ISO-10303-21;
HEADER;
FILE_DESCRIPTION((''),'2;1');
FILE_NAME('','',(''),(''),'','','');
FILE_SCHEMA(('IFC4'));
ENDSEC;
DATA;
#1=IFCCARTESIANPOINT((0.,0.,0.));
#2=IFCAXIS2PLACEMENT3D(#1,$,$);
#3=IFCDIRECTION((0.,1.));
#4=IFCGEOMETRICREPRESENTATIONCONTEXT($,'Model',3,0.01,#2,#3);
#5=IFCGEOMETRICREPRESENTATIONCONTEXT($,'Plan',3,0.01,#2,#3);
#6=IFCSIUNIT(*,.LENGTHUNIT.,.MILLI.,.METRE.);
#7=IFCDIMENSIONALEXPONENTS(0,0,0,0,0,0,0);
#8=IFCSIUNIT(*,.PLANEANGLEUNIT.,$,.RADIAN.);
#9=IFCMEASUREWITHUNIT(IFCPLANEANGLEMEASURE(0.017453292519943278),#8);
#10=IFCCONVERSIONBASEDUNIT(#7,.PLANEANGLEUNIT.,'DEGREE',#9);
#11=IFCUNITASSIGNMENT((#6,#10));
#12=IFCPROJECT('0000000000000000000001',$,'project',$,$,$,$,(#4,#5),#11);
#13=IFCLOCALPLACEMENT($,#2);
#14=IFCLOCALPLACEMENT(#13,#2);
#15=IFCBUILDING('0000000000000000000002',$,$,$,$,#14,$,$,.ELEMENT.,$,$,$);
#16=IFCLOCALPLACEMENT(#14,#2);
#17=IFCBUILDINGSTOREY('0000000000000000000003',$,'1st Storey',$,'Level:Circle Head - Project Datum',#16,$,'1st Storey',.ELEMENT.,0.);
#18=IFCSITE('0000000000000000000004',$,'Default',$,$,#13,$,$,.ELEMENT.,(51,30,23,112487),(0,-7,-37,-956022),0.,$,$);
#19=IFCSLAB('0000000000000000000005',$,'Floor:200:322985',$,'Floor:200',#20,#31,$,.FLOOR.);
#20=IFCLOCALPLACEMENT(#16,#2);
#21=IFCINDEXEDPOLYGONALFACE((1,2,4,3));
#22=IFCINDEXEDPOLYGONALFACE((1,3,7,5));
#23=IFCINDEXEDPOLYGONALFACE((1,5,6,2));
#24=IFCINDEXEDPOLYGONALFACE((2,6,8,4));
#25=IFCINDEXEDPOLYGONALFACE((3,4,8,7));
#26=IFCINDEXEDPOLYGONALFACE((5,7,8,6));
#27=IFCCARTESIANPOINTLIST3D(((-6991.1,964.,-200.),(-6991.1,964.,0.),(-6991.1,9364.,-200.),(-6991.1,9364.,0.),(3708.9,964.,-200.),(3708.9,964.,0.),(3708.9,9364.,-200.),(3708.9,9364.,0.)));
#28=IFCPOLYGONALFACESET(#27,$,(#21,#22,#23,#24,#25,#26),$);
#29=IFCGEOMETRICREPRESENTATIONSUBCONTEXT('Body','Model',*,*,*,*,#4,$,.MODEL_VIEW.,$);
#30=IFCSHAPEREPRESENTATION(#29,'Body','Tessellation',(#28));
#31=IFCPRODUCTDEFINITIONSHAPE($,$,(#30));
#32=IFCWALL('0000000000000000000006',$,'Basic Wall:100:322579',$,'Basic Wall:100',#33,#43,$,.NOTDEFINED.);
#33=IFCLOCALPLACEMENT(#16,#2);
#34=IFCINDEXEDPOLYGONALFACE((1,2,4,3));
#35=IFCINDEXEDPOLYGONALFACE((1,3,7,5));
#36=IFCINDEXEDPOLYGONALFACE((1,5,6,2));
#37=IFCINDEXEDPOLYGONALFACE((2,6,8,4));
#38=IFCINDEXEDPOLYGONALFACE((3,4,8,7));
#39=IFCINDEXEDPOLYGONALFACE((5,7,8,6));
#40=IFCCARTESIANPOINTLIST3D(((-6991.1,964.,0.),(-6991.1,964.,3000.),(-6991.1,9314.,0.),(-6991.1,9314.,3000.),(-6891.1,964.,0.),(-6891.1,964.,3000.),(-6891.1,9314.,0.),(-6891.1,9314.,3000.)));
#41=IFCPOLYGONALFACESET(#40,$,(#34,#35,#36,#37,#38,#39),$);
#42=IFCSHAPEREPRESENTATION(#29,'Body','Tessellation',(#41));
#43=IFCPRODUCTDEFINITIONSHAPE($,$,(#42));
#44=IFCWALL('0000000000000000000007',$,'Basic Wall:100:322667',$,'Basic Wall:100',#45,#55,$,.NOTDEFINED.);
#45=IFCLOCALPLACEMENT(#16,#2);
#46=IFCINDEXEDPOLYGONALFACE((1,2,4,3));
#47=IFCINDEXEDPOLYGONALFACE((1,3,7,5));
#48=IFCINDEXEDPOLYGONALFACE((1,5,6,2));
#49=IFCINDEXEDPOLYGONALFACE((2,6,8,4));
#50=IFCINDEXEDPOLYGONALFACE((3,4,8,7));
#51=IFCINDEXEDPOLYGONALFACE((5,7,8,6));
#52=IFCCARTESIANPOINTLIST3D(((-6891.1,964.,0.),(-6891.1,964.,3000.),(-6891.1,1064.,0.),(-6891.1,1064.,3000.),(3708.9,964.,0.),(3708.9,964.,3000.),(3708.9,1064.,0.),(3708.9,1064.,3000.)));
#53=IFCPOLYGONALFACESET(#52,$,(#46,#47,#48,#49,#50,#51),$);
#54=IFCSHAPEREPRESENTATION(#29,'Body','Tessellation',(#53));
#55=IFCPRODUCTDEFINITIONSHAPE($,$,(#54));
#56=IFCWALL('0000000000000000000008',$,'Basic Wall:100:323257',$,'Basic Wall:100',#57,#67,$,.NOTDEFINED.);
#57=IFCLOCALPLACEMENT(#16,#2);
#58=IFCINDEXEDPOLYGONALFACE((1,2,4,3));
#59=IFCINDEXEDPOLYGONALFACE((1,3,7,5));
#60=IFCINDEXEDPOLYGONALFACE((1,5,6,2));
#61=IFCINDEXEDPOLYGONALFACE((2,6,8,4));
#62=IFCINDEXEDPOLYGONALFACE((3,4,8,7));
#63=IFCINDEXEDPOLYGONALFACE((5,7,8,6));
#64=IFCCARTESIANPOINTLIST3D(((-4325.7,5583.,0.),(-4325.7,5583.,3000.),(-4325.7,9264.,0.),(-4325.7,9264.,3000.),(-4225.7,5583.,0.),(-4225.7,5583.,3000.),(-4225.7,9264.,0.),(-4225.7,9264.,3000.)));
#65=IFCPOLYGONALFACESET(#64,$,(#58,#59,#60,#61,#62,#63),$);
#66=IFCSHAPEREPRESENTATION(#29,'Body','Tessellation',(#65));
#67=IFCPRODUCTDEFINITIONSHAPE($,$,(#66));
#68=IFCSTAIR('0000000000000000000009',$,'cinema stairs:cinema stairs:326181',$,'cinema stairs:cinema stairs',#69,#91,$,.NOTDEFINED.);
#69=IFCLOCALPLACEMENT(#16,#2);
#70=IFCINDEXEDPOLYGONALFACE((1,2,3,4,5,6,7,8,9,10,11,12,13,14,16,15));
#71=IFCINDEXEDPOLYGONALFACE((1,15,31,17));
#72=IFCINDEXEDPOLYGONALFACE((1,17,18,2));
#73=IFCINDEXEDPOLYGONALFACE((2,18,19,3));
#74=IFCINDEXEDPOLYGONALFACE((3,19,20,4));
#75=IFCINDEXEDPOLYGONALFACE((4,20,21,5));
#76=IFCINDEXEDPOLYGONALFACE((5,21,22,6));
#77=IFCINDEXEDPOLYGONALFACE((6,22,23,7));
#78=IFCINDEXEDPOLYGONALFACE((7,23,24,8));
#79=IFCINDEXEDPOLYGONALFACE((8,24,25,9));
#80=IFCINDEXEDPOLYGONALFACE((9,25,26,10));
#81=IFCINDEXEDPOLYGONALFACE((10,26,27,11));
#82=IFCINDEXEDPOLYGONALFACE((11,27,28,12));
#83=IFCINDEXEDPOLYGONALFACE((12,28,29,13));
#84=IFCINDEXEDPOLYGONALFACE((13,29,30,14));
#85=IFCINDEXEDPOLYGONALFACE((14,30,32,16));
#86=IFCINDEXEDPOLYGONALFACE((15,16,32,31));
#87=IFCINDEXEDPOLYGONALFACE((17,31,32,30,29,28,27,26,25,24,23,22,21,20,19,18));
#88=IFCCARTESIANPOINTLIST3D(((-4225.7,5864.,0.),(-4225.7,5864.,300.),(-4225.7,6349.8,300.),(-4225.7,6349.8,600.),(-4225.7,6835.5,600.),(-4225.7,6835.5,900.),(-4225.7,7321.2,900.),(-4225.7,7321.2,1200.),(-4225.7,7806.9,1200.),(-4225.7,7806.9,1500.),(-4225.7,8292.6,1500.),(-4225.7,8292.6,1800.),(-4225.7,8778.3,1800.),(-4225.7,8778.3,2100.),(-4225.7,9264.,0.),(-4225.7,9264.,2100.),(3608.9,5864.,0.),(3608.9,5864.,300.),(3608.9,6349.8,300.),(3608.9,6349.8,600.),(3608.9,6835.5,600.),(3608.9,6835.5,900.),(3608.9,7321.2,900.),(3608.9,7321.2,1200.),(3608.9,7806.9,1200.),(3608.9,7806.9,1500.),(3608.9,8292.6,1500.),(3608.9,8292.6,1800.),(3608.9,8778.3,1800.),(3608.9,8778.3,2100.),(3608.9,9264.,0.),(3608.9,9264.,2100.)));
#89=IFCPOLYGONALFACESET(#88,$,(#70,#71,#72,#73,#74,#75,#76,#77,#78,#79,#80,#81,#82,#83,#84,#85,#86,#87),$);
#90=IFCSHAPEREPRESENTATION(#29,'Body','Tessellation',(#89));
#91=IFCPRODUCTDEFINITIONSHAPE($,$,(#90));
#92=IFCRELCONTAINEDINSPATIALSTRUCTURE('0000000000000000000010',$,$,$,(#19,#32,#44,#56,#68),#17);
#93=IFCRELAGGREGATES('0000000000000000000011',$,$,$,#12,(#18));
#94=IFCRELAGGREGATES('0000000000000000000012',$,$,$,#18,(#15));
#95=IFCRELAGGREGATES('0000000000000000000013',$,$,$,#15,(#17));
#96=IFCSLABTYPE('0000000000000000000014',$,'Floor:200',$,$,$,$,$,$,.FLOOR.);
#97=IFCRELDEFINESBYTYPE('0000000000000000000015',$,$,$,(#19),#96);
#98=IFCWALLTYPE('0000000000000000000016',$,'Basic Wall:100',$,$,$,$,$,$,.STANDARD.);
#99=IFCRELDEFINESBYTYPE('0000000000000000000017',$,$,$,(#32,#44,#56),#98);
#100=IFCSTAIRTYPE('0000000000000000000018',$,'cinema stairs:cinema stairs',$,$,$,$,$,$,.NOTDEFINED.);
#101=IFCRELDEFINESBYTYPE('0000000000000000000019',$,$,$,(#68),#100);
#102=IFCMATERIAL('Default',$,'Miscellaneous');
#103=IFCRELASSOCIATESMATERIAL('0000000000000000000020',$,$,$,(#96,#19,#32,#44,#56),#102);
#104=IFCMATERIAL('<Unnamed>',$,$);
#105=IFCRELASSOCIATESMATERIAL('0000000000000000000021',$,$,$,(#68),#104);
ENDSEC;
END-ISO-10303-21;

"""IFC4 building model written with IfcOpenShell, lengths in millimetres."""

from ifc_helpers import new_model, entity, si_unit, converted_unit, direction, frame, origin, place, context, subcontext, project, spatial, indexed_curve, outline, extrude, material, type_object, element, save


model = new_model("IFC4")

# Units and contexts
model_context = context("Model", 3, precision=0.01, world=origin(), true_north=direction((0.0, 1.0)))
plan_context = context("Plan", 3, precision=0.01, world=origin(), true_north=direction((0.0, 1.0)))
body_context = subcontext(model_context, "Body", "Model", "MODEL_VIEW")
ifc_project = project(units=[si_unit("LENGTHUNIT", "METRE", prefix="MILLI"), converted_unit("PLANEANGLEUNIT", "DEGREE", entity("IfcPlaneAngleMeasure", 0.017453292519943278), si_unit("PLANEANGLEUNIT", "RADIAN"), dimensions=[0, 0, 0, 0, 0, 0, 0])], contexts=[model_context, plan_context])

# Site, building, storey
site_placement = place(None, origin())
site = spatial("IfcSite", under=ifc_project, at=site_placement, Name="Default", CompositionType="ELEMENT", RefLatitude=(51, 30, 23, 112487), RefLongitude=(0, -7, -37, -956022), RefElevation=0.0)
building_placement = place(site_placement, origin())
building = spatial("IfcBuilding", under=site, at=building_placement, CompositionType="ELEMENT")
storey_placement = place(building_placement, origin())
storey = spatial("IfcBuildingStorey", under=building, at=storey_placement, Name="1st Storey", ObjectType="Level:Circle Head - Project Datum", LongName="1st Storey", CompositionType="ELEMENT", Elevation=0.0)

# Shared definitions
ifc_material_1 = material(Name="<Unnamed>")

# Slab
ifc_material_2 = material(Name="Default", Category="Miscellaneous")
slab_type = type_object("IfcSlabType", Name="Floor:200", PredefinedType="FLOOR", material=ifc_material_2)
slab_placement = place(storey_placement, origin())
element("IfcSlab", 1, at=slab_placement, inside=storey, type_object=slab_type, material=ifc_material_2, Name="Floor:200:322985", ObjectType="Floor:200", PredefinedType="FLOOR", context=body_context, shape_type="SweptSolid", body=[
    extrude(outline(indexed_curve([(-4200.0, -5350.0), (4200.0, -5350.0), (4200.0, 5350.0), (-4200.0, 5350.0), (-4200.0, -5350.0)], self_intersect=False)), frame((-1641.1, 5164.0, 0.0), z_axis=(0.0, 0.0, -1.0), x_axis=(0.0, 1.0, 0.0)), (0.0, 0.0, 1.0), 200.0),
])

# Walls
wall_type = type_object("IfcWallType", Name="Basic Wall:100", PredefinedType="STANDARD")
wall_1_placement = place(storey_placement, frame((-6941.1, 9314.0, 0.0), z_axis=(0.0, 0.0, 1.0), x_axis=(0.0, -1.0, 0.0)))
element("IfcWall", 2, at=wall_1_placement, inside=storey, type_object=wall_type, material=ifc_material_2, Name="Basic Wall:100:322579", ObjectType="Basic Wall:100", PredefinedType="NOTDEFINED", context=body_context, shape_type="SweptSolid", body=[
    extrude(outline(indexed_curve([(8350.0, 50.0), (0.0, 50.0), (0.0, -50.0), (8350.0, -50.0), (8350.0, 50.0)], self_intersect=False)), origin(), (0.0, 0.0, 1.0), 3000.0),
])
wall_2_placement = place(storey_placement, frame((-6891.1, 1014.0, 0.0)))
element("IfcWall", 3, at=wall_2_placement, inside=storey, type_object=wall_type, material=ifc_material_2, Name="Basic Wall:100:322667", ObjectType="Basic Wall:100", PredefinedType="NOTDEFINED", context=body_context, shape_type="SweptSolid", body=[
    extrude(outline(indexed_curve([(10600.0, 50.0), (0.0, 50.0), (0.0, -50.0), (10600.0, -50.0), (10600.0, 50.0)], self_intersect=False)), origin(), (0.0, 0.0, 1.0), 3000.0),
])
wall_3_placement = place(storey_placement, frame((-4275.7, 5583.0, 0.0), z_axis=(0.0, 0.0, 1.0), x_axis=(0.0, 1.0, 0.0)))
element("IfcWall", 4, at=wall_3_placement, inside=storey, type_object=wall_type, material=ifc_material_2, Name="Basic Wall:100:323257", ObjectType="Basic Wall:100", PredefinedType="NOTDEFINED", context=body_context, shape_type="SweptSolid", body=[
    extrude(outline(indexed_curve([(3681.0, 50.0), (0.0, 50.0), (0.0, -50.0), (3681.0, -50.0), (3681.0, 50.0)], self_intersect=False)), origin(), (0.0, 0.0, 1.0), 3000.0),
])

# Stair
stair_type_1 = type_object("IfcStairType", Name="cinema stairs:cinema stairs", PredefinedType="NOTDEFINED")
stair_1_placement = place(storey_placement, origin())
element("IfcStair", 5, at=stair_1_placement, inside=storey, type_object=stair_type_1, material=ifc_material_1, Name="cinema stairs:cinema stairs:326181", ObjectType="cinema stairs:cinema stairs", PredefinedType="NOTDEFINED", context=body_context, shape_type="SweptSolid", body=[
    extrude(outline(indexed_curve([(-1700.0, -1050.0), (-1214.3, -1050.0), (-1214.3, -750.0), (-728.6, -750.0), (-728.6, -450.0), (-242.9, -450.0), (-242.9, -150.0), (242.9, -150.0), (242.9, 150.0), (728.6, 150.0), (728.6, 450.0), (1214.3, 450.0), (1214.3, 750.0), (1700.0, 750.0), (1700.0, 1050.0), (-1700.0, 1050.0), (-1700.0, -1050.0)], self_intersect=False)), frame((-4225.7, 7564.0, 1050.0), z_axis=(1.0, 0.0, 0.0), x_axis=(0.0, -1.0, 0.0)), (0.0, 0.0, 1.0), 7834.6),
])

save(model, "model.ifc")
